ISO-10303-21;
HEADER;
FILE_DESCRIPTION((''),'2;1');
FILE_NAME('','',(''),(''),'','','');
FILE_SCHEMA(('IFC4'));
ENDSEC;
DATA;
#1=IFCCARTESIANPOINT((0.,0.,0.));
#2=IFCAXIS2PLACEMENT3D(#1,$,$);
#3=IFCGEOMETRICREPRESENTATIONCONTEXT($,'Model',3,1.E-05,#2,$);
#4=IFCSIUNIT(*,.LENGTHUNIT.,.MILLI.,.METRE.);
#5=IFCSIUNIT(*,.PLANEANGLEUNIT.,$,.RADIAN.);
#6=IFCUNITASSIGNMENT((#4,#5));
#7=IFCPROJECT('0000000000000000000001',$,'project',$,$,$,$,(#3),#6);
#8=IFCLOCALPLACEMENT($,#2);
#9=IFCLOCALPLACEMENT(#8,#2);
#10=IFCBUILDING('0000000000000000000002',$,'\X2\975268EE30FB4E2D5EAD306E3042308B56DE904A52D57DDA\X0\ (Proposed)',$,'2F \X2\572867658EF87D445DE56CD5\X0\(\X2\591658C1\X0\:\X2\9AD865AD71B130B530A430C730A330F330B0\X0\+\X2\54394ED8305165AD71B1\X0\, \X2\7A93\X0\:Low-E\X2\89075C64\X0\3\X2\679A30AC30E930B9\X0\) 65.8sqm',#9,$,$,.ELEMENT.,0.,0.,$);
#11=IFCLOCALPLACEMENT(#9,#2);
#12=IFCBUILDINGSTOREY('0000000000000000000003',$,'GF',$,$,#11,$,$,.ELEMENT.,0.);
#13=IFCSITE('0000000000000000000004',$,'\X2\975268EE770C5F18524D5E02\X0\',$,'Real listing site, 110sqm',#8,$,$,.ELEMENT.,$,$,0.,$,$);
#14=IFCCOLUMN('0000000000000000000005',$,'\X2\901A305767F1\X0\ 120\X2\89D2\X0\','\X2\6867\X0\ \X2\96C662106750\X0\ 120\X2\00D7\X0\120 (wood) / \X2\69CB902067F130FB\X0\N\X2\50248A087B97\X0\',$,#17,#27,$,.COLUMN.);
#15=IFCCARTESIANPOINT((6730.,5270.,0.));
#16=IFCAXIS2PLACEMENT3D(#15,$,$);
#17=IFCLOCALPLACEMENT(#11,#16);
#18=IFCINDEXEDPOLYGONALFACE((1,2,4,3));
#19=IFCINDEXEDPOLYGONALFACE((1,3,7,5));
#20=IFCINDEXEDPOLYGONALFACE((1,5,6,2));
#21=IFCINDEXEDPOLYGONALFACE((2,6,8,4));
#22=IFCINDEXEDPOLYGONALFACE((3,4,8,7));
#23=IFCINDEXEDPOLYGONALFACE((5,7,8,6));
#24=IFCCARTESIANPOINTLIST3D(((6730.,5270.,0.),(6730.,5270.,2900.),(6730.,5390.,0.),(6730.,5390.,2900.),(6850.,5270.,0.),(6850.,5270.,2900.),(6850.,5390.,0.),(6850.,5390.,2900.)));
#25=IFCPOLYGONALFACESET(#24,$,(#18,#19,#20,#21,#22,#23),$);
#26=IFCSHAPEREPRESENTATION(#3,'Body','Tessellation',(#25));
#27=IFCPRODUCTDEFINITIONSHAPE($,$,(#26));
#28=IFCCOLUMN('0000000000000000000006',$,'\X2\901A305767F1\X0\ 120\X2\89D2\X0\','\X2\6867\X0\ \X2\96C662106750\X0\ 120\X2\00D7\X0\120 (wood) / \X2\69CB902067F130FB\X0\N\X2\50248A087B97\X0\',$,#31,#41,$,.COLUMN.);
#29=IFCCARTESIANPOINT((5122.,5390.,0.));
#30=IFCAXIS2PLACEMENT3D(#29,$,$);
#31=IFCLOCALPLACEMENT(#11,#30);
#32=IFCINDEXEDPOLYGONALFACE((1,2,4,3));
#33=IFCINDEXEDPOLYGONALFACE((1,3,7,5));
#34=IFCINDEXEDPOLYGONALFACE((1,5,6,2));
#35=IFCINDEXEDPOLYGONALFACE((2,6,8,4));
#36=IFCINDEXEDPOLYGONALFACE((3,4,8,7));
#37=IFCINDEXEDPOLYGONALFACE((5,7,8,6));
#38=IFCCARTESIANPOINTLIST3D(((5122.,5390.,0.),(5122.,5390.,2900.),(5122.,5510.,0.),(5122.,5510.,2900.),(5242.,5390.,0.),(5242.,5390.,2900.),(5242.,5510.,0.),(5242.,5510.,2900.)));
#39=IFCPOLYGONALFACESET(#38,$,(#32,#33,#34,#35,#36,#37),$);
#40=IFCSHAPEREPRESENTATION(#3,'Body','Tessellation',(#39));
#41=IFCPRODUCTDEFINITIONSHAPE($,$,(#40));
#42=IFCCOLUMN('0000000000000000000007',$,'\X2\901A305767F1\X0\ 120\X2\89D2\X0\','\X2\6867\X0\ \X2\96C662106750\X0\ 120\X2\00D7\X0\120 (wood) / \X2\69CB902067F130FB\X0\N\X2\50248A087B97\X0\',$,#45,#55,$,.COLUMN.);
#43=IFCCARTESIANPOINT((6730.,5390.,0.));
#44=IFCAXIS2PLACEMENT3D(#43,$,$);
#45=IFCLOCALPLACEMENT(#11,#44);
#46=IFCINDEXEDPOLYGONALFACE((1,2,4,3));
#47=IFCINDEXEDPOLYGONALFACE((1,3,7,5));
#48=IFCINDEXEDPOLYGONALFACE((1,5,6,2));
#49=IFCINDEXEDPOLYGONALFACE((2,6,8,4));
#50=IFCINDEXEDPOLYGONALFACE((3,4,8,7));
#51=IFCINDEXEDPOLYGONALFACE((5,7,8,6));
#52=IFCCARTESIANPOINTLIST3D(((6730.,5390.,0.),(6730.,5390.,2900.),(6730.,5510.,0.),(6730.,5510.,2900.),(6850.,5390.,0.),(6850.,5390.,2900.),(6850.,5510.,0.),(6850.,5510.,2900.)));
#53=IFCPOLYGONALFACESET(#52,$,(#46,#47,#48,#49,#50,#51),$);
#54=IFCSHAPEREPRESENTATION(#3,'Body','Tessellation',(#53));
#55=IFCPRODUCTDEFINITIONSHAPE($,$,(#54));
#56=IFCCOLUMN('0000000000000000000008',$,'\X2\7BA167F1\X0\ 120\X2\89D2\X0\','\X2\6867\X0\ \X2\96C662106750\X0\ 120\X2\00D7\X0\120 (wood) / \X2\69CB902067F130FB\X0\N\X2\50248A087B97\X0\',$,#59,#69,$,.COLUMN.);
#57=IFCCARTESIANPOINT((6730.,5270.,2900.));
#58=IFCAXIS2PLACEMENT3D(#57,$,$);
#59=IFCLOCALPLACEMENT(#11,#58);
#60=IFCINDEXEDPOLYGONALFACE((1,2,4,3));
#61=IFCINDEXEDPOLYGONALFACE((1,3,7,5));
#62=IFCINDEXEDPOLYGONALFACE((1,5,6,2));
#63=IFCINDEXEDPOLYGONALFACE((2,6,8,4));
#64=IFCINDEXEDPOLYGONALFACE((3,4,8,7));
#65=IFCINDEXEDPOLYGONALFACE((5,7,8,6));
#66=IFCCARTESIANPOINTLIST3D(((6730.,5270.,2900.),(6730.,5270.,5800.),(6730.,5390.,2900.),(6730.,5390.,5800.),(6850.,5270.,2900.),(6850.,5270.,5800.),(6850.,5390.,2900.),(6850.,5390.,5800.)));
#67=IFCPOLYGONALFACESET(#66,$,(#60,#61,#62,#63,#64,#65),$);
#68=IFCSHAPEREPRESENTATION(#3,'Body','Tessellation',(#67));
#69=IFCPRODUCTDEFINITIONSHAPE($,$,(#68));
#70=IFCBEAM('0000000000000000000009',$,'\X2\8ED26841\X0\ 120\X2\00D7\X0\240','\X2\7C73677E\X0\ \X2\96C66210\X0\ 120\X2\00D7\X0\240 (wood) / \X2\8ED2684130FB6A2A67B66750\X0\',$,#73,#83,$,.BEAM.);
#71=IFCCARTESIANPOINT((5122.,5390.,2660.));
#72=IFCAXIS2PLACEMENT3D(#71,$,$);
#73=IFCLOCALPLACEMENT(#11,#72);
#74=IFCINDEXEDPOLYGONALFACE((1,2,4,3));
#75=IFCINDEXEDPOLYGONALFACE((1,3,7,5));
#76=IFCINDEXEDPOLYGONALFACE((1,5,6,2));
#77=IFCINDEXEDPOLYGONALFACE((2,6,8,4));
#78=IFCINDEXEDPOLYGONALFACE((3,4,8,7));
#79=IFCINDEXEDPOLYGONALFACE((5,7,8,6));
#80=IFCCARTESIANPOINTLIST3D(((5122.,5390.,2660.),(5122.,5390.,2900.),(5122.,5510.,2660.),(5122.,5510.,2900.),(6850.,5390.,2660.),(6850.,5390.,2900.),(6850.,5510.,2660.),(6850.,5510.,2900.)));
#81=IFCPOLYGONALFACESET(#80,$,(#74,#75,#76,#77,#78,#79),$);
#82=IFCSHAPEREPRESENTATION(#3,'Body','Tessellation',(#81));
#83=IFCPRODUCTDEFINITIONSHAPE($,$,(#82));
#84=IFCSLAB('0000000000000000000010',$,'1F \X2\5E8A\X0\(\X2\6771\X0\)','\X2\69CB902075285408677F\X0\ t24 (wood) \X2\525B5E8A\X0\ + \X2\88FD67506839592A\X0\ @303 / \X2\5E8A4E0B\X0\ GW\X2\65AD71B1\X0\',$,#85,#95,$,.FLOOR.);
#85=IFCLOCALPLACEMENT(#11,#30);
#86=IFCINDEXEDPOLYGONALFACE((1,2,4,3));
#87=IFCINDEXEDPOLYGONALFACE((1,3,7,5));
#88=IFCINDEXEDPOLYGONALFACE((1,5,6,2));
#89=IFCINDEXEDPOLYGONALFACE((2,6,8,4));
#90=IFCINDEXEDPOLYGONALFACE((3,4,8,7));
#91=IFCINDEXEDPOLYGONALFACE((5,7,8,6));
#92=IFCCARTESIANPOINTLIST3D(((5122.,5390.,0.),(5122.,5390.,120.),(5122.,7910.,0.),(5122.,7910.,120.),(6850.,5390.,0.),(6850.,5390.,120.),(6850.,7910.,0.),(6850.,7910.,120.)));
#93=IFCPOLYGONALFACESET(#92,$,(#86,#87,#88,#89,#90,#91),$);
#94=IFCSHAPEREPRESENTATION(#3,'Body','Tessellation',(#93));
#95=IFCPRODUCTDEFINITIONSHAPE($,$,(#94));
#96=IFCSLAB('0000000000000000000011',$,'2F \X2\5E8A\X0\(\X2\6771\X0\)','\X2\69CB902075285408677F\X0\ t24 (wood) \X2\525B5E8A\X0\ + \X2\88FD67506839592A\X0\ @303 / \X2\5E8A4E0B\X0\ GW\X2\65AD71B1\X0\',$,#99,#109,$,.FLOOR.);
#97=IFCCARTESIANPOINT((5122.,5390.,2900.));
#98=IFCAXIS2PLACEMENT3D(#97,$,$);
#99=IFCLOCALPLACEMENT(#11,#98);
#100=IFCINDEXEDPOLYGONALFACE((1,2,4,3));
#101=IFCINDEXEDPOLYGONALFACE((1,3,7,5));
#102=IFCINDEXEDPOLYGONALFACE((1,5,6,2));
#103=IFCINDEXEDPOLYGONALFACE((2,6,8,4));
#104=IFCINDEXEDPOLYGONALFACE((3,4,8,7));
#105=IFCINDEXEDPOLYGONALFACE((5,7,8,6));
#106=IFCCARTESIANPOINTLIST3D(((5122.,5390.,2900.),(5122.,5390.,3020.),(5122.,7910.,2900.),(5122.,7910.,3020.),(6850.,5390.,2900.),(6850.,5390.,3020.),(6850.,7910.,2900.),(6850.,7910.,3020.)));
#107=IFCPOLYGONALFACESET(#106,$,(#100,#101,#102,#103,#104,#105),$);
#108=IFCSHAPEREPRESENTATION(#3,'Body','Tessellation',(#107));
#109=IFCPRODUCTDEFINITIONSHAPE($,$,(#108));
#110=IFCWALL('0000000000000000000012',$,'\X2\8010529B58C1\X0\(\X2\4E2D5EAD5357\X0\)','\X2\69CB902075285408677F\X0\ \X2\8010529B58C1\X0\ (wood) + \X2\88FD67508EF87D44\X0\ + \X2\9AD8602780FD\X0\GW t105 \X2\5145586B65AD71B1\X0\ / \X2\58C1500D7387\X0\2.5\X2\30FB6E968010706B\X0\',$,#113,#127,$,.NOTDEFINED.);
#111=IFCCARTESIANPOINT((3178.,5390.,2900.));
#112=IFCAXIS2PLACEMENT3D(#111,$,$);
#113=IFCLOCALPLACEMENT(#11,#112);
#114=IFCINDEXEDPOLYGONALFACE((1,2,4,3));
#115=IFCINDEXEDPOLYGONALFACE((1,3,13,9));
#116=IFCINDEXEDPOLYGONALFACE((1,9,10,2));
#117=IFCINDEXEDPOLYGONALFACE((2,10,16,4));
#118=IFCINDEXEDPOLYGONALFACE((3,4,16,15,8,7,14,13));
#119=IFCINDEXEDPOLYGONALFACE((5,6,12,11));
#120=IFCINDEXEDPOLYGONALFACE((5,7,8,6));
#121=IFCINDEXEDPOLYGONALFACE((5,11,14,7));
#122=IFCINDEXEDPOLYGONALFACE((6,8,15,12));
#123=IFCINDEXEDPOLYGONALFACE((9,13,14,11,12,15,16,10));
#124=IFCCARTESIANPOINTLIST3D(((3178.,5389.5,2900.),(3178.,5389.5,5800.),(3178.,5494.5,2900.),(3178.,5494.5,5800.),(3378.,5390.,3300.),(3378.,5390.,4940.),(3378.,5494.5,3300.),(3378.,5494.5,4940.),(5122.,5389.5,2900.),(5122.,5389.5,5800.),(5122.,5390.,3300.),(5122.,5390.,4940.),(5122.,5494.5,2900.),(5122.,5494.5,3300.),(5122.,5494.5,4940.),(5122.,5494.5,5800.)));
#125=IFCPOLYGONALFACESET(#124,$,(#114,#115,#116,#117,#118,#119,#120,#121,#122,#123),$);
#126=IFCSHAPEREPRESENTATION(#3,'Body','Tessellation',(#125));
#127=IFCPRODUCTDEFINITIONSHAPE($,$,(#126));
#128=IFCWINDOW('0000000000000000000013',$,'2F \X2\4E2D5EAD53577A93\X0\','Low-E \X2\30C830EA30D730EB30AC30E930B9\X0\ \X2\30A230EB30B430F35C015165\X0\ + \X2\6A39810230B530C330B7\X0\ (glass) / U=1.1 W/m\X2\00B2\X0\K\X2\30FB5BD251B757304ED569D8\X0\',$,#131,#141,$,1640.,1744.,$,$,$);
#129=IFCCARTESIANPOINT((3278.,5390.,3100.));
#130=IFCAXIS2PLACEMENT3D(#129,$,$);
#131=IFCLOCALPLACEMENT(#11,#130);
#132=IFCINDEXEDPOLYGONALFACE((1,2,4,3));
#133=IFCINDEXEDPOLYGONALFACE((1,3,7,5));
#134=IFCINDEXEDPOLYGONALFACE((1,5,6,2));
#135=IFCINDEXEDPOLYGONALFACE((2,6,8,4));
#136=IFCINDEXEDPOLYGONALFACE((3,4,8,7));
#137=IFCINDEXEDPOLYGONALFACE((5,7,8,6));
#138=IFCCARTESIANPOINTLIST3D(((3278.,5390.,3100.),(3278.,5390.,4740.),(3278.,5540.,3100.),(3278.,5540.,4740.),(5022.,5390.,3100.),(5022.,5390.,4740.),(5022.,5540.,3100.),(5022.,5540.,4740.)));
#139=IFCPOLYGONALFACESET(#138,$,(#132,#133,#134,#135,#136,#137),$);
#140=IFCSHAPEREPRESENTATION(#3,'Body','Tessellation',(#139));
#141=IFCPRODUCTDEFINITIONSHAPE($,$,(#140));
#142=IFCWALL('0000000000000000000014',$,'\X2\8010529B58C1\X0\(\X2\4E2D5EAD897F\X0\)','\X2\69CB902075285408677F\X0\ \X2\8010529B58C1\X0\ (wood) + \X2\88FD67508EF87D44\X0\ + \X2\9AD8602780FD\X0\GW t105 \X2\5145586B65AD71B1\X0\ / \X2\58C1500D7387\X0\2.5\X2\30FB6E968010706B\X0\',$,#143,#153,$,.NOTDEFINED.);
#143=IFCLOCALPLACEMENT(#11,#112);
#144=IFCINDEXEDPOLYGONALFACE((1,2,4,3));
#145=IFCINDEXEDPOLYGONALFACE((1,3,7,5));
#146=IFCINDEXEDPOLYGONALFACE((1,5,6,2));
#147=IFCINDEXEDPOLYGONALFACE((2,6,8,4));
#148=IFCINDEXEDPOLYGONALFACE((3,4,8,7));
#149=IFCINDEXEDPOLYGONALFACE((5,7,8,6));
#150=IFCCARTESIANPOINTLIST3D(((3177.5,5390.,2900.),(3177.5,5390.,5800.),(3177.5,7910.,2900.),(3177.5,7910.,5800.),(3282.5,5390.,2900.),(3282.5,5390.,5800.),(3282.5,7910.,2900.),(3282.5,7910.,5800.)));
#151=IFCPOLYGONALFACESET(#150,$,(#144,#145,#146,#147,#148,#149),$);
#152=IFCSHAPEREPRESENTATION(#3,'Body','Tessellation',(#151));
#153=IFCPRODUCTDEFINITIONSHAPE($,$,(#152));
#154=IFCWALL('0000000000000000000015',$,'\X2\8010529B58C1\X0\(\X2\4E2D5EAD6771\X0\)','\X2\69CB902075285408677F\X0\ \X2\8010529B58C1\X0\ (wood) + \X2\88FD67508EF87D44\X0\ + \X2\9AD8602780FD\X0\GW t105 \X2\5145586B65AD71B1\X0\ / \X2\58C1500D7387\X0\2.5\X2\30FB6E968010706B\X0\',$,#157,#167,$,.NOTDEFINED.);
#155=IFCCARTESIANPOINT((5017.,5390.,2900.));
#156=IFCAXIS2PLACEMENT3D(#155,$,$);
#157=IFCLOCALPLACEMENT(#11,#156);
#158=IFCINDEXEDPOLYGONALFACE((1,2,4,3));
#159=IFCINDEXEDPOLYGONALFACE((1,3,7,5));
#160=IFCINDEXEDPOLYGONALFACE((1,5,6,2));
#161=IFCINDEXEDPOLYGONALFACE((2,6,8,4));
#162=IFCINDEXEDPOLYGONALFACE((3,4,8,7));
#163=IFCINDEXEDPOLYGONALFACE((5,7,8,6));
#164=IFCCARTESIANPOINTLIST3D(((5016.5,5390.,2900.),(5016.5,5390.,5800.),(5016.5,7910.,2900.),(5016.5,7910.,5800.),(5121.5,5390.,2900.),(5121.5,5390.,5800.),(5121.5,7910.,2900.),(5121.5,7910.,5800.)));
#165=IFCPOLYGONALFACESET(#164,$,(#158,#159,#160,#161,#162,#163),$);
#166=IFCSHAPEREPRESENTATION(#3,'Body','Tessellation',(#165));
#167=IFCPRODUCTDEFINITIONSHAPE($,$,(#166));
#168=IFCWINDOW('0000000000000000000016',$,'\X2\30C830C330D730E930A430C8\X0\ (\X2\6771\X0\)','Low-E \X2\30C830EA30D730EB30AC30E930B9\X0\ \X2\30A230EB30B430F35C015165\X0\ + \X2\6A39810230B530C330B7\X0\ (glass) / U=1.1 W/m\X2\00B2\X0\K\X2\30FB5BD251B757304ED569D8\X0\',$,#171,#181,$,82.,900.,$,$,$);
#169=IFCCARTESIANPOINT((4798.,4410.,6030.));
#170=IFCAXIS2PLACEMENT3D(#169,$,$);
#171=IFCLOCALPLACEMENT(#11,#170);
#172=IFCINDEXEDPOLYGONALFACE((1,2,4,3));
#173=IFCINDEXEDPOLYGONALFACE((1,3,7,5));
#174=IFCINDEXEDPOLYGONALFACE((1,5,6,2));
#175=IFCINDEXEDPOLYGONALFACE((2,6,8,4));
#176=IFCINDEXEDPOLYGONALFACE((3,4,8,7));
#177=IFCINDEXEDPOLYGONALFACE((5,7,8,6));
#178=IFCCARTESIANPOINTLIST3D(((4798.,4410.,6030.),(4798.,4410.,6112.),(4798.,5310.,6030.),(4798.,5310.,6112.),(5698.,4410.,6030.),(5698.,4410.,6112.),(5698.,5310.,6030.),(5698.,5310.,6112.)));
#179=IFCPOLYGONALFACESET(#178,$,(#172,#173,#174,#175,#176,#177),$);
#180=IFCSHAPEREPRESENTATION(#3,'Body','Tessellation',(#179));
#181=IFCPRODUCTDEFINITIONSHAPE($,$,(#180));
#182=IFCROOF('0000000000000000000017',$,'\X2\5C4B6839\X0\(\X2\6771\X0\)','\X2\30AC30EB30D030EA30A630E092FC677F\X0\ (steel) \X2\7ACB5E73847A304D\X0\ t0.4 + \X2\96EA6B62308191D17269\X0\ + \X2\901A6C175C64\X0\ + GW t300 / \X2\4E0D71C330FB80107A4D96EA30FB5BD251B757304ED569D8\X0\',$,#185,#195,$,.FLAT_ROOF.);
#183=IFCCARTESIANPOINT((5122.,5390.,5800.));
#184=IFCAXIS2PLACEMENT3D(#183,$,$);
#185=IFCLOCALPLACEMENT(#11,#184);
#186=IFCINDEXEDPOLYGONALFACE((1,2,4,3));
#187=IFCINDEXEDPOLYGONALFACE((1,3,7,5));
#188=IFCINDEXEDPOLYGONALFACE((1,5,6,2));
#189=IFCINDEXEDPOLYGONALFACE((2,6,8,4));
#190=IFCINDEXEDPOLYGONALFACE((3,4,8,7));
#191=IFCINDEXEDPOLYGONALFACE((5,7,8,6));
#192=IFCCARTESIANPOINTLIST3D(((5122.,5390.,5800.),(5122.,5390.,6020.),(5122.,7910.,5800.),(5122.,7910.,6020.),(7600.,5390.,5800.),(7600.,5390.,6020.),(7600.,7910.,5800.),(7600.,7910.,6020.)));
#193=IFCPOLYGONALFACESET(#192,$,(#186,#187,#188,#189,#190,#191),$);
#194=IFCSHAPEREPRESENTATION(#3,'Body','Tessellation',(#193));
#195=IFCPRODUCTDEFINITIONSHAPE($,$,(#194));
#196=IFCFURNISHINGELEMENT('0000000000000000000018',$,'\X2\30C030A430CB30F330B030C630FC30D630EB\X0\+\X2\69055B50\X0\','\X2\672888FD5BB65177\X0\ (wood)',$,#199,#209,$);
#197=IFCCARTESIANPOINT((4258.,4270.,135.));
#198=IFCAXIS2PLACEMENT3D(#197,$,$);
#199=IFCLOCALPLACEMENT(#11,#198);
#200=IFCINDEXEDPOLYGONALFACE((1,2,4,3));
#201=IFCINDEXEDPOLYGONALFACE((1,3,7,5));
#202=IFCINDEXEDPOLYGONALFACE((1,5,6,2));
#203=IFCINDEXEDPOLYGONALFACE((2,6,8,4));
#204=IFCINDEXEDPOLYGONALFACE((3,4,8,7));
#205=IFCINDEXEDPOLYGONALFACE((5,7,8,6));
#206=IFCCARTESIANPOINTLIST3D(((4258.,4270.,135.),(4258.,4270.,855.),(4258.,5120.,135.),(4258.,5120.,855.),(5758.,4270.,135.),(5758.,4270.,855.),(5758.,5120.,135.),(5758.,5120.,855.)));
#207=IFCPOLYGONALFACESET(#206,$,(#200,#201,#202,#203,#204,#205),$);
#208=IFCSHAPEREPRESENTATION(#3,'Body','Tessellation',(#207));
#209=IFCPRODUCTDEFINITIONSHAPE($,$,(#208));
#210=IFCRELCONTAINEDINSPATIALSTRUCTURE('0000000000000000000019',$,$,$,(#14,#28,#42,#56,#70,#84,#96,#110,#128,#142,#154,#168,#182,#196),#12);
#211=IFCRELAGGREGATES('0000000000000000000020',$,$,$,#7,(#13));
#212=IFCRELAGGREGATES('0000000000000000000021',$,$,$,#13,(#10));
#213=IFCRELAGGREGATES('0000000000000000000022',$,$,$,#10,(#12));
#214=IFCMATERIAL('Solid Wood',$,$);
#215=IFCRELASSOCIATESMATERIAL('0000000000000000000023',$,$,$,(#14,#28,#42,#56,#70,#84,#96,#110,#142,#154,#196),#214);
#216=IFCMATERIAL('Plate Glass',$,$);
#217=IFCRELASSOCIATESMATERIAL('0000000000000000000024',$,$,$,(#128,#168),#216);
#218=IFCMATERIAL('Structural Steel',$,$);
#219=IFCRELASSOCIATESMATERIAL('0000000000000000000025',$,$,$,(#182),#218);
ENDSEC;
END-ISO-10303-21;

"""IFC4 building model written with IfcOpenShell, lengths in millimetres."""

from ifc_helpers import new_model, si_unit, frame, frame_2d, origin, place, context, project, spatial, rectangle, extrude, material, element, fill, save


model = new_model("IFC4")

# Units and contexts
model_context = context("Model", 3, precision=1e-05, world=origin())
ifc_project = project(units=[si_unit("LENGTHUNIT", "METRE", prefix="MILLI"), si_unit("PLANEANGLEUNIT", "RADIAN")], contexts=[model_context])

# Site, building, storey
site_placement = place(None, origin())
site = spatial("IfcSite", under=ifc_project, at=site_placement, Name="青森県弘前市", ObjectType="Real listing site, 110sqm", CompositionType="ELEMENT", RefElevation=0.0)
building_placement = place(site_placement, origin())
building = spatial("IfcBuilding", under=site, at=building_placement, Name="青森・中庭のある回遊動線 (Proposed)", ObjectType="2F 在来軸組工法(外壁:高断熱サイディング+吹付け断熱, 窓:Low-E複層3枚ガラス) 65.8sqm", CompositionType="ELEMENT", ElevationOfRefHeight=0.0, ElevationOfTerrain=0.0)
storey_placement = place(building_placement, origin())
storey = spatial("IfcBuildingStorey", under=building, at=storey_placement, Name="GF", CompositionType="ELEMENT", Elevation=0.0)

# Columns
ifc_material_1 = material(Name="Solid Wood")
column_1_placement = place(storey_placement, frame((6730.0, 5270.0, 0.0)))
element("IfcColumn", 1, at=column_1_placement, inside=storey, material=ifc_material_1, Name="通し柱 120角", Description="桧 集成材 120×120 (wood) / 構造柱・N値計算", PredefinedType="COLUMN", context=model_context, shape_type="SweptSolid", body=[
    extrude(rectangle(XDim=120.0, YDim=120.0, at=frame_2d((60.0, 60.0))), frame((6730.0, 5270.0, 0.0)), (0.0, 0.0, 1.0), 2900.0),
])
column_2_placement = place(storey_placement, frame((5122.0, 5390.0, 0.0)))
element("IfcColumn", 2, at=column_2_placement, inside=storey, material=ifc_material_1, Name="通し柱 120角", Description="桧 集成材 120×120 (wood) / 構造柱・N値計算", PredefinedType="COLUMN", context=model_context, shape_type="SweptSolid", body=[
    extrude(rectangle(XDim=120.0, YDim=120.0, at=frame_2d((60.0, 60.0))), frame((5122.0, 5390.0, 0.0)), (0.0, 0.0, 1.0), 2900.0),
])
column_3_placement = place(storey_placement, frame((6730.0, 5390.0, 0.0)))
element("IfcColumn", 3, at=column_3_placement, inside=storey, material=ifc_material_1, Name="通し柱 120角", Description="桧 集成材 120×120 (wood) / 構造柱・N値計算", PredefinedType="COLUMN", context=model_context, shape_type="SweptSolid", body=[
    extrude(rectangle(XDim=120.0, YDim=120.0, at=frame_2d((60.0, 60.0))), frame((6730.0, 5390.0, 0.0)), (0.0, 0.0, 1.0), 2900.0),
])
column_4_placement = place(storey_placement, frame((6730.0, 5270.0, 2900.0)))
element("IfcColumn", 4, at=column_4_placement, inside=storey, material=ifc_material_1, Name="管柱 120角", Description="桧 集成材 120×120 (wood) / 構造柱・N値計算", PredefinedType="COLUMN", context=model_context, shape_type="SweptSolid", body=[
    extrude(rectangle(XDim=120.0, YDim=120.0, at=frame_2d((60.0, 60.0))), frame((6730.0, 5270.0, 2900.0)), (0.0, 0.0, 1.0), 2900.0),
])

# Beam
beam_1_placement = place(storey_placement, frame((5122.0, 5390.0, 2660.0)))
element("IfcBeam", 5, at=beam_1_placement, inside=storey, material=ifc_material_1, Name="軒桁 120×240", Description="米松 集成 120×240 (wood) / 軒桁・横架材", PredefinedType="BEAM", context=model_context, shape_type="SweptSolid", body=[
    extrude(rectangle(XDim=1728.0, YDim=120.0, at=frame_2d((864.0, 60.0))), frame((5122.0, 5390.0, 2660.0)), (0.0, 0.0, 1.0), 240.0),
])

# Slabs
slab_1_placement = place(storey_placement, frame((5122.0, 5390.0, 0.0)))
element("IfcSlab", 6, at=slab_1_placement, inside=storey, material=ifc_material_1, Name="1F 床(東)", Description="構造用合板 t24 (wood) 剛床 + 製材根太 @303 / 床下 GW断熱", PredefinedType="FLOOR", context=model_context, shape_type="SweptSolid", body=[
    extrude(rectangle(XDim=1728.0, YDim=2520.0, at=frame_2d((864.0, 1260.0))), frame((5122.0, 5390.0, 0.0)), (0.0, 0.0, 1.0), 120.0),
])
slab_2_placement = place(storey_placement, frame((5122.0, 5390.0, 2900.0)))
element("IfcSlab", 7, at=slab_2_placement, inside=storey, material=ifc_material_1, Name="2F 床(東)", Description="構造用合板 t24 (wood) 剛床 + 製材根太 @303 / 床下 GW断熱", PredefinedType="FLOOR", context=model_context, shape_type="SweptSolid", body=[
    extrude(rectangle(XDim=1728.0, YDim=2520.0, at=frame_2d((864.0, 1260.0))), frame((5122.0, 5390.0, 2900.0)), (0.0, 0.0, 1.0), 120.0),
])

# Wall, opening, window
wall_1_placement = place(storey_placement, frame((3178.0, 5390.0, 2900.0)))
wall_1 = element("IfcWall", 8, at=wall_1_placement, inside=storey, material=ifc_material_1, Name="耐力壁(中庭南)", Description="構造用合板 耐力壁 (wood) + 製材軸組 + 高性能GW t105 充填断熱 / 壁倍率2.5・準耐火", PredefinedType="NOTDEFINED", context=model_context, shape_type="SweptSolid", body=[
    extrude(rectangle(XDim=1944.0, YDim=105.0, at=frame_2d((972.0, 52.0))), frame((3178.0, 5390.0, 2900.0)), (0.0, 0.0, 1.0), 2900.0),
])
opening_placement = place(storey_placement, frame((3278.0, 5390.0, 3100.0)))
opening = element("IfcOpeningElement", 9, at=opening_placement, cuts=wall_1, PredefinedType="NOTDEFINED", context=model_context, shape_type="SweptSolid", body=[
    extrude(rectangle(XDim=1744.0, YDim=150.0, at=frame_2d((872.0, 75.0))), frame((3278.0, 5390.0, 3100.0)), (0.0, 0.0, 1.0), 1640.0),
])
ifc_material_2 = material(Name="Plate Glass")
window_1_placement = place(storey_placement, frame((3278.0, 5390.0, 3100.0)))
window_1 = element("IfcWindow", 10, at=window_1_placement, inside=storey, material=ifc_material_2, Name="2F 中庭南窓", Description="Low-E トリプルガラス アルゴン封入 + 樹脂サッシ (glass) / U=1.1 W/m²K・寒冷地仕様", OverallHeight=1640.0, OverallWidth=1744.0, context=model_context, shape_type="SweptSolid", body=[
    extrude(rectangle(XDim=1744.0, YDim=150.0, at=frame_2d((872.0, 75.0))), frame((3278.0, 5390.0, 3100.0)), (0.0, 0.0, 1.0), 1640.0),
])
fill(opening, window_1)

# Walls
wall_2_placement = place(storey_placement, frame((3178.0, 5390.0, 2900.0)))
element("IfcWall", 11, at=wall_2_placement, inside=storey, material=ifc_material_1, Name="耐力壁(中庭西)", Description="構造用合板 耐力壁 (wood) + 製材軸組 + 高性能GW t105 充填断熱 / 壁倍率2.5・準耐火", PredefinedType="NOTDEFINED", context=model_context, shape_type="SweptSolid", body=[
    extrude(rectangle(XDim=105.0, YDim=2520.0, at=frame_2d((52.0, 1260.0))), frame((3178.0, 5390.0, 2900.0)), (0.0, 0.0, 1.0), 2900.0),
])
wall_3_placement = place(storey_placement, frame((5017.0, 5390.0, 2900.0)))
element("IfcWall", 12, at=wall_3_placement, inside=storey, material=ifc_material_1, Name="耐力壁(中庭東)", Description="構造用合板 耐力壁 (wood) + 製材軸組 + 高性能GW t105 充填断熱 / 壁倍率2.5・準耐火", PredefinedType="NOTDEFINED", context=model_context, shape_type="SweptSolid", body=[
    extrude(rectangle(XDim=105.0, YDim=2520.0, at=frame_2d((52.0, 1260.0))), frame((5017.0, 5390.0, 2900.0)), (0.0, 0.0, 1.0), 2900.0),
])

# Window
window_2_placement = place(storey_placement, frame((4798.0, 4410.0, 6030.0)))
element("IfcWindow", 13, at=window_2_placement, inside=storey, material=ifc_material_2, Name="トップライト (東)", Description="Low-E トリプルガラス アルゴン封入 + 樹脂サッシ (glass) / U=1.1 W/m²K・寒冷地仕様", OverallHeight=82.0, OverallWidth=900.0, context=model_context, shape_type="SweptSolid", body=[
    extrude(rectangle(XDim=900.0, YDim=900.0, at=frame_2d((450.0, 450.0))), frame((4798.0, 4410.0, 6030.0)), (0.0, 0.0, 1.0), 82.0),
])

# Roof
ifc_material_3 = material(Name="Structural Steel")
for number, where, name in (
    (14, (5122.0, 5390.0, 5800.0), "屋根(東)"),
):
    element("IfcRoof", number, at=place(storey_placement, frame(where)), inside=storey, material=ifc_material_3, Name=name, Description="ガルバリウム鋼板 (steel) 立平葺き t0.4 + 雪止め金物 + 通気層 + GW t300 / 不燃・耐積雪・寒冷地仕様", PredefinedType="FLAT_ROOF", context=model_context, shape_type="SweptSolid", body=[
        extrude(rectangle(XDim=2478.0, YDim=2520.0, at=frame_2d((1239.0, 1260.0))), frame((5122.0, 5390.0, 5800.0)), (0.0, 0.0, 1.0), 220.0),
    ])

# Furnishing element
furnishing_1_placement = place(storey_placement, frame((4258.0, 4270.0, 135.0)))
element("IfcFurnishingElement", 15, at=furnishing_1_placement, inside=storey, material=ifc_material_1, Name="ダイニングテーブル+椅子", Description="木製家具 (wood)", context=model_context, shape_type="SweptSolid", body=[
    extrude(rectangle(XDim=1500.0, YDim=850.0, at=frame_2d((750.0, 425.0))), frame((4258.0, 4270.0, 135.0)), (0.0, 0.0, 1.0), 720.0),
])

save(model, "model.ifc")
